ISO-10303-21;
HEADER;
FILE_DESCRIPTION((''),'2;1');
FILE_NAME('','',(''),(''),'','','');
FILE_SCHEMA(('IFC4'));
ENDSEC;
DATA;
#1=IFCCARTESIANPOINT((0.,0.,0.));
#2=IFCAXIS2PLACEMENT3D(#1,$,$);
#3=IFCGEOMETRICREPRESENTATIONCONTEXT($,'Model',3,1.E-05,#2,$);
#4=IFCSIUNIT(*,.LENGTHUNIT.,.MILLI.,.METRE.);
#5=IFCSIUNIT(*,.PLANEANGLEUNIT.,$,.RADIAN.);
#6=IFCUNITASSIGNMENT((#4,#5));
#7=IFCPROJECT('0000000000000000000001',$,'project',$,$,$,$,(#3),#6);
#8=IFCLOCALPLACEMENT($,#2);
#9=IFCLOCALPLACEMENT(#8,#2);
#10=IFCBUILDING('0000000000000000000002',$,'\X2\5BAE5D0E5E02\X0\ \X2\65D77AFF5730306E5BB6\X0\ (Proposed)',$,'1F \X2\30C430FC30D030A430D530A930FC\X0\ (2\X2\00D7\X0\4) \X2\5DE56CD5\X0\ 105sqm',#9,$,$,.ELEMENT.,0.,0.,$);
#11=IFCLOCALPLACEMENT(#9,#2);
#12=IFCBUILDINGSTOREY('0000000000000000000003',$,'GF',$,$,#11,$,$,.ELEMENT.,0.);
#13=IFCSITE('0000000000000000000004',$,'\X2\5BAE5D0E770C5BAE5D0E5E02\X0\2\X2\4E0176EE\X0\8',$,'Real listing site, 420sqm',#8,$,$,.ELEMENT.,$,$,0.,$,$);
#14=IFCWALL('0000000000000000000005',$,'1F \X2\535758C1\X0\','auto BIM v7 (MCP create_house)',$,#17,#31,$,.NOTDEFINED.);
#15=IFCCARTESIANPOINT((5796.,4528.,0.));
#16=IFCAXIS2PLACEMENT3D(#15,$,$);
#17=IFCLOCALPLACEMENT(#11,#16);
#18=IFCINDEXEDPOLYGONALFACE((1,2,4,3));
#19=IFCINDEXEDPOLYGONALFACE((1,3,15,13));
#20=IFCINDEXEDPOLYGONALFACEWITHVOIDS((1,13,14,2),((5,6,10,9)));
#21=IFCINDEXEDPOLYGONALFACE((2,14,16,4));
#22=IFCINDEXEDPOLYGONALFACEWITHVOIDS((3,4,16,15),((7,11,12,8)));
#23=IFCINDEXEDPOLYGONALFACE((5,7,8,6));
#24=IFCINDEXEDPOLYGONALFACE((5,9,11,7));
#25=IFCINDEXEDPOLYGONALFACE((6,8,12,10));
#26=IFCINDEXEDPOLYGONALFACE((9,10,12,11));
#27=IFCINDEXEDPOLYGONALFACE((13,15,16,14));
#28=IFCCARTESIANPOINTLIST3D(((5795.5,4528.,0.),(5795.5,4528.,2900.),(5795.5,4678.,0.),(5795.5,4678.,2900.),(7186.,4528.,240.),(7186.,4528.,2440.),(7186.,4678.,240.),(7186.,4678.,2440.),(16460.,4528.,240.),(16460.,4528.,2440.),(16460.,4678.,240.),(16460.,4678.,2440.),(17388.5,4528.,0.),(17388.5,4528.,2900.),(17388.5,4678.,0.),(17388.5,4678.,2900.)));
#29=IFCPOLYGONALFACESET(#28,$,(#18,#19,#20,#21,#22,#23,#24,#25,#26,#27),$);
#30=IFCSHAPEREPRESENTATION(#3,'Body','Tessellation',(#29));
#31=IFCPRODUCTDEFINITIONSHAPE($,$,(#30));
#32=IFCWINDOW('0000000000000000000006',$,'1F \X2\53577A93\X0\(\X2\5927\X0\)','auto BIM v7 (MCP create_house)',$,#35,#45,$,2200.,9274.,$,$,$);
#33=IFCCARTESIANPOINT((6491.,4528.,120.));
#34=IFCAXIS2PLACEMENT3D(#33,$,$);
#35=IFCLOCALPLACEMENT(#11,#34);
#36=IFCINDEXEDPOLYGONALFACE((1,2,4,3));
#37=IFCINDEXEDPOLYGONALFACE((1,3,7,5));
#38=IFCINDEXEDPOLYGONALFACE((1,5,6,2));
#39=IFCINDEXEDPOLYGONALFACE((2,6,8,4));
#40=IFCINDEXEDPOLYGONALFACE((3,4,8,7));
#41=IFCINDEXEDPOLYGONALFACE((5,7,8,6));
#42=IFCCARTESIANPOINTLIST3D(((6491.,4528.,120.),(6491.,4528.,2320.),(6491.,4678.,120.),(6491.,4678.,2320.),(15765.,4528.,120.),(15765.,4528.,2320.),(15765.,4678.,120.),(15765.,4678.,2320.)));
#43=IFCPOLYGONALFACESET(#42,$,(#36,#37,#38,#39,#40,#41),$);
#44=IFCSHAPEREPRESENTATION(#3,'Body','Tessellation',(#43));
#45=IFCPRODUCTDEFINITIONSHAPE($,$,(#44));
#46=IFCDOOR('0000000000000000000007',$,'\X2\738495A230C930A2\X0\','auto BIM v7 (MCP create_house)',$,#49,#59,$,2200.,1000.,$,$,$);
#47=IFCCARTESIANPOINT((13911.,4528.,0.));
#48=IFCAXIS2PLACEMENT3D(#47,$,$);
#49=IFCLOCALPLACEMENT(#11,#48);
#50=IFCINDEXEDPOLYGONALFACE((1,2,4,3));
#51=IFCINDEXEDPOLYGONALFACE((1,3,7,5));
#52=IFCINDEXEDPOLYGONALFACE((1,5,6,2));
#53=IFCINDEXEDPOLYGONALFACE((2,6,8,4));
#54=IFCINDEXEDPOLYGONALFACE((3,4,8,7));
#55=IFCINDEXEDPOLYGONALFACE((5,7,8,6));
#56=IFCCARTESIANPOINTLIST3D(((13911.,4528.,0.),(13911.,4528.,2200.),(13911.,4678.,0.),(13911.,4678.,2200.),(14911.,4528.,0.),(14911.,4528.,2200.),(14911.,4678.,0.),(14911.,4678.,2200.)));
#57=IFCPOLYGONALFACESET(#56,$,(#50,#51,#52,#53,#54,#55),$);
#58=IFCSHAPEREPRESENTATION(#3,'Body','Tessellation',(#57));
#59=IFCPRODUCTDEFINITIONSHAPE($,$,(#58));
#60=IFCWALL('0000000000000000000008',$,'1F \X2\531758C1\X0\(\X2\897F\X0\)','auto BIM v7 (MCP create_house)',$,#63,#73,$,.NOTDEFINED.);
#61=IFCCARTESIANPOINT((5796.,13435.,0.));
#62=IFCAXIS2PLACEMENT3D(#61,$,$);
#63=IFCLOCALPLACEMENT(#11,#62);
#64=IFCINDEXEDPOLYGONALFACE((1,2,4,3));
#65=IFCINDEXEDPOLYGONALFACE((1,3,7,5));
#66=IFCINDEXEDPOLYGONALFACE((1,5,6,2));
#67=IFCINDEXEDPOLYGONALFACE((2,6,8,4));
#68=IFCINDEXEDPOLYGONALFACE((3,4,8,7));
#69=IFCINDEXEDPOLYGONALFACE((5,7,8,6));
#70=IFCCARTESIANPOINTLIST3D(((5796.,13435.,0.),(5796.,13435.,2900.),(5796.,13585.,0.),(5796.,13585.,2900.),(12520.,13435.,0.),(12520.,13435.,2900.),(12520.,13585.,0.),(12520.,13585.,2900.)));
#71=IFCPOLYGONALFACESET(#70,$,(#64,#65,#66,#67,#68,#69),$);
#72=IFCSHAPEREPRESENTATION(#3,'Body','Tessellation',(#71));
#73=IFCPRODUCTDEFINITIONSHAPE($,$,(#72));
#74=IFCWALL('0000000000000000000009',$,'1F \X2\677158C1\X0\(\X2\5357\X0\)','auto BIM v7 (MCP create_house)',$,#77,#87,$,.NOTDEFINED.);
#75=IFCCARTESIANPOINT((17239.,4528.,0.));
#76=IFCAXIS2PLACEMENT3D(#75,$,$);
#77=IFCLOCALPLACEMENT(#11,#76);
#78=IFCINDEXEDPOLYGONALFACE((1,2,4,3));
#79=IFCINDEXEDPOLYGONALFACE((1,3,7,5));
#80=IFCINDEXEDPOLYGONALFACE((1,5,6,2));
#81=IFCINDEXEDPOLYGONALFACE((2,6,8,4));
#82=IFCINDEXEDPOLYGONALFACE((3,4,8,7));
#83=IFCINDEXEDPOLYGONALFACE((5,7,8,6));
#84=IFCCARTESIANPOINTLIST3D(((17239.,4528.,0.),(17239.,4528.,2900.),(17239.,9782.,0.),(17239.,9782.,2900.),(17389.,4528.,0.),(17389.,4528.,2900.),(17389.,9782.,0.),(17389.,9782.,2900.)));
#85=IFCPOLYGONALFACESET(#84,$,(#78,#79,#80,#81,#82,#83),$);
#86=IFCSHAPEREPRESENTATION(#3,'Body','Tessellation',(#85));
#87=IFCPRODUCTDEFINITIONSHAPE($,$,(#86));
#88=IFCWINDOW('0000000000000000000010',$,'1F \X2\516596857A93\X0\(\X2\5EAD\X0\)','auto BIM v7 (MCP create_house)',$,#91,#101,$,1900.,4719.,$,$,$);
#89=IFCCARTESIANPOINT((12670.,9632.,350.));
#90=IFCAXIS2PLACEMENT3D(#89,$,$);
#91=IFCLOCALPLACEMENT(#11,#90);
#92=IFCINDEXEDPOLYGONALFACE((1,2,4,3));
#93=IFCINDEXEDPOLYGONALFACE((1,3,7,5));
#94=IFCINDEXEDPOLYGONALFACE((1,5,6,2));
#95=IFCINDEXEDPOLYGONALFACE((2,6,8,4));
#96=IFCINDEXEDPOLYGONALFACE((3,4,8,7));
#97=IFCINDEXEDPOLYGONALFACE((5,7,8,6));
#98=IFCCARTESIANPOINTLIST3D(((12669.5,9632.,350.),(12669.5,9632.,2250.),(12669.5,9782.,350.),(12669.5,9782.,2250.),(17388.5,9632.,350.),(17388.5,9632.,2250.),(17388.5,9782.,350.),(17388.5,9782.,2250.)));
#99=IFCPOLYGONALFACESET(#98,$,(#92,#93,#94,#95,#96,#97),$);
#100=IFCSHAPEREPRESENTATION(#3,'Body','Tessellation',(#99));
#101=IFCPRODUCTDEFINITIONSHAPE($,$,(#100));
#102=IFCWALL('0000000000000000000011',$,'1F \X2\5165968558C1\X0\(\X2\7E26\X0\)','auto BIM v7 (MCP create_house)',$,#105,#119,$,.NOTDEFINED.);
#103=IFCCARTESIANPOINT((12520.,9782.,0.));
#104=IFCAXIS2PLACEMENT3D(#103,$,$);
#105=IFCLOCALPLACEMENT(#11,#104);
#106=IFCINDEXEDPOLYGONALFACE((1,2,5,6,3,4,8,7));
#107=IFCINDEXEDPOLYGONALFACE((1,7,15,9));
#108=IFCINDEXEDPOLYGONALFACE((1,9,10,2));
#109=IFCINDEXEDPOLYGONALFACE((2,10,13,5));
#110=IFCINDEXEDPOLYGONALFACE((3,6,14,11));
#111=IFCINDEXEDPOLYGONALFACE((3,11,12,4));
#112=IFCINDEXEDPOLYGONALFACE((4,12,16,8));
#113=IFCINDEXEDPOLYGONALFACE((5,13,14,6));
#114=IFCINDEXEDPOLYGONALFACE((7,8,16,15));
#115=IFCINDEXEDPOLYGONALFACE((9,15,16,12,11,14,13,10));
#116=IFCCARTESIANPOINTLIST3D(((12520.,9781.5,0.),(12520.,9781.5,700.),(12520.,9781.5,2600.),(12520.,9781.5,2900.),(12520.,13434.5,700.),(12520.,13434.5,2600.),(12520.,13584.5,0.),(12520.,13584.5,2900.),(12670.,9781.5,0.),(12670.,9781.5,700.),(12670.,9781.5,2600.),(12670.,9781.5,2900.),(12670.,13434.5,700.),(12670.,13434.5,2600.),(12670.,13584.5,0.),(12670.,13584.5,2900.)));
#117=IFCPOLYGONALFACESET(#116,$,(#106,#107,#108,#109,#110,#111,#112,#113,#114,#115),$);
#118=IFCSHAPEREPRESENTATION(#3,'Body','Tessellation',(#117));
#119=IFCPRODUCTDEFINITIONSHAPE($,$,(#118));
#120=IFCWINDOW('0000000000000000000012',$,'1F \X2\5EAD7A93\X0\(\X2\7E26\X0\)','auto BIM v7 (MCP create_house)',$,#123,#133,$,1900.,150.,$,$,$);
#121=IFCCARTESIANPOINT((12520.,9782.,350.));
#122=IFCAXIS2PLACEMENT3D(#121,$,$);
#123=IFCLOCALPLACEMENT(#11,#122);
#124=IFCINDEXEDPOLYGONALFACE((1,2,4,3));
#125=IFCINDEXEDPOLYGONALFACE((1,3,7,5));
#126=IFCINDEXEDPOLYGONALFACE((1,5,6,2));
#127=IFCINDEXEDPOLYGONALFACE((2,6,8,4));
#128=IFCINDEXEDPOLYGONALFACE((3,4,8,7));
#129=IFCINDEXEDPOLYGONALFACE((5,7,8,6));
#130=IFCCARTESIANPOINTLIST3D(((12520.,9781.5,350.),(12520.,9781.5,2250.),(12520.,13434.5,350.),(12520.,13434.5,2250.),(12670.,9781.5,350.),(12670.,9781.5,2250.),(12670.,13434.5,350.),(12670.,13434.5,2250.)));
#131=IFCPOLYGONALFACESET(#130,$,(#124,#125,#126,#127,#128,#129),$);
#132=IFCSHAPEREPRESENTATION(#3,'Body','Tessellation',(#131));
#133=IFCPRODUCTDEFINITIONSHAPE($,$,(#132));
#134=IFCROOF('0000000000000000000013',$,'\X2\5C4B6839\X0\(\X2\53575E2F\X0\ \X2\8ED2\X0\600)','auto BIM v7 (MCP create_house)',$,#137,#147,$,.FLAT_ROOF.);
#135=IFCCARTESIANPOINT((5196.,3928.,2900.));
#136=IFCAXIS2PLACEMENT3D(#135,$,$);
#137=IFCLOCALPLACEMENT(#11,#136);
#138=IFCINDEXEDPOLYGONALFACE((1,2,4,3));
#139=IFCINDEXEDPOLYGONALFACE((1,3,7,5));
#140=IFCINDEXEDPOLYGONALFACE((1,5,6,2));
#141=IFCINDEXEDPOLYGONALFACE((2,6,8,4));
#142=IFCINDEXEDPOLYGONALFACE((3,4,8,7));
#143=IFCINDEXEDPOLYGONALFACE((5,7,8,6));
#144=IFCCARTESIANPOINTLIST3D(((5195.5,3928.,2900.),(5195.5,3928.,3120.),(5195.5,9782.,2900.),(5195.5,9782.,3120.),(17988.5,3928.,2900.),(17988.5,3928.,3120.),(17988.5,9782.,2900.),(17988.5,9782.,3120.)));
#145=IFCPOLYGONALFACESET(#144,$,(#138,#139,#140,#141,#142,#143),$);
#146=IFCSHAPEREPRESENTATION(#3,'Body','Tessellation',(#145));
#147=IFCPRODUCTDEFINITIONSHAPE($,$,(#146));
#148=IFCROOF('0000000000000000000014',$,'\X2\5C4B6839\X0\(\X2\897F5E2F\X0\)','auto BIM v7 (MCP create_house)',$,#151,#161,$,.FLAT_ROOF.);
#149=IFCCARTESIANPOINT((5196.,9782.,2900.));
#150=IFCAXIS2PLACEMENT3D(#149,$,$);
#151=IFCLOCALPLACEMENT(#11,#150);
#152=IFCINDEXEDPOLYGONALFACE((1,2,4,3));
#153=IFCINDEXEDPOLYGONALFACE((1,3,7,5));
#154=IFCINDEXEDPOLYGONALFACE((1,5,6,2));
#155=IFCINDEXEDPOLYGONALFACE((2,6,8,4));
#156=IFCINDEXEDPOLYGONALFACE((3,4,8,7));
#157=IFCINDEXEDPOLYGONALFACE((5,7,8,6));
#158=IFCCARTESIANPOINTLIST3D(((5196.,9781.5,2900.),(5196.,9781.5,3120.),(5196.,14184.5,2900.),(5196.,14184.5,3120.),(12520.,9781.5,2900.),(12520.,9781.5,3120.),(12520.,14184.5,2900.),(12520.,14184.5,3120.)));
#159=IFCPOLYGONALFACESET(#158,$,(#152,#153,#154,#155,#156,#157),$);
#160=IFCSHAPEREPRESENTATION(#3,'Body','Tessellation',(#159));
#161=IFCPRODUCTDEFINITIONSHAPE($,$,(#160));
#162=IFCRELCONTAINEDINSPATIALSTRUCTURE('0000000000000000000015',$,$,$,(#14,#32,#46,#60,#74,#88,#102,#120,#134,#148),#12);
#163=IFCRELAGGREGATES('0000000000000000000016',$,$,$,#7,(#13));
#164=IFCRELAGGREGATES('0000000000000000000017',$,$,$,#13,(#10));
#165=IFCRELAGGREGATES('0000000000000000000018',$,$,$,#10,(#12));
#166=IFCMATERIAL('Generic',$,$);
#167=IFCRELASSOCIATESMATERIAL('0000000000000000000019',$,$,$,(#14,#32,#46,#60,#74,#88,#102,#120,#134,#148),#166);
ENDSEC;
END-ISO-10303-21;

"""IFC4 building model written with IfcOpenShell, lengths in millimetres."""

from ifc_helpers import new_model, si_unit, frame, frame_2d, origin, place, context, project, spatial, rectangle, extrude, material, element, fill, save


model = new_model("IFC4")

# Units and contexts
model_context = context("Model", 3, precision=1e-05, world=origin())
ifc_project = project(units=[si_unit("LENGTHUNIT", "METRE", prefix="MILLI"), si_unit("PLANEANGLEUNIT", "RADIAN")], contexts=[model_context])

# Site, building, storey
site_placement = place(None, origin())
site = spatial("IfcSite", under=ifc_project, at=site_placement, Name="宮崎県宮崎市2丁目8", ObjectType="Real listing site, 420sqm", CompositionType="ELEMENT", RefElevation=0.0)
building_placement = place(site_placement, origin())
building = spatial("IfcBuilding", under=site, at=building_placement, Name="宮崎市 旗竿地の家 (Proposed)", ObjectType="1F ツーバイフォー (2×4) 工法 105sqm", CompositionType="ELEMENT", ElevationOfRefHeight=0.0, ElevationOfTerrain=0.0)
storey_placement = place(building_placement, origin())
storey = spatial("IfcBuildingStorey", under=building, at=storey_placement, Name="GF", CompositionType="ELEMENT", Elevation=0.0)

# Shared definitions
ifc_material = material(Name="Generic")

# Wall, openings, window, door
wall_1_placement = place(storey_placement, frame((5796.0, 4528.0, 0.0)))
wall_1 = element("IfcWall", 1, at=wall_1_placement, inside=storey, material=ifc_material, Name="1F 南壁", Description="auto BIM v7 (MCP create_house)", PredefinedType="NOTDEFINED", context=model_context, shape_type="SweptSolid", body=[
    extrude(rectangle(XDim=11593.0, YDim=150.0, at=frame_2d((5796.0, 75.0))), frame((5796.0, 4528.0, 0.0)), (0.0, 0.0, 1.0), 2900.0),
])
opening_1_placement = place(storey_placement, frame((6491.0, 4528.0, 120.0)))
opening_1 = element("IfcOpeningElement", 2, at=opening_1_placement, cuts=wall_1, PredefinedType="NOTDEFINED", context=model_context, shape_type="SweptSolid", body=[
    extrude(rectangle(XDim=9274.0, YDim=150.0, at=frame_2d((4637.0, 75.0))), frame((6491.0, 4528.0, 120.0)), (0.0, 0.0, 1.0), 2200.0),
])
opening_2_placement = place(storey_placement, frame((13911.0, 4528.0, 0.0)))
opening_2 = element("IfcOpeningElement", 3, at=opening_2_placement, cuts=wall_1, PredefinedType="NOTDEFINED", context=model_context, shape_type="SweptSolid", body=[
    extrude(rectangle(XDim=1000.0, YDim=150.0, at=frame_2d((500.0, 75.0))), frame((13911.0, 4528.0, 0.0)), (0.0, 0.0, 1.0), 2200.0),
])
window_1_placement = place(storey_placement, frame((6491.0, 4528.0, 120.0)))
window_1 = element("IfcWindow", 4, at=window_1_placement, inside=storey, material=ifc_material, Name="1F 南窓(大)", Description="auto BIM v7 (MCP create_house)", OverallHeight=2200.0, OverallWidth=9274.0, context=model_context, shape_type="SweptSolid", body=[
    extrude(rectangle(XDim=9274.0, YDim=150.0, at=frame_2d((4637.0, 75.0))), frame((6491.0, 4528.0, 120.0)), (0.0, 0.0, 1.0), 2200.0),
])
fill(opening_1, window_1)
door_placement = place(storey_placement, frame((13911.0, 4528.0, 0.0)))
door = element("IfcDoor", 5, at=door_placement, inside=storey, material=ifc_material, Name="玄関ドア", Description="auto BIM v7 (MCP create_house)", OverallHeight=2200.0, OverallWidth=1000.0, context=model_context, shape_type="SweptSolid", body=[
    extrude(rectangle(XDim=1000.0, YDim=150.0, at=frame_2d((500.0, 75.0))), frame((13911.0, 4528.0, 0.0)), (0.0, 0.0, 1.0), 2200.0),
])
fill(opening_2, door)

# Wall
wall_2_placement = place(storey_placement, frame((5796.0, 13435.0, 0.0)))
element("IfcWall", 6, at=wall_2_placement, inside=storey, material=ifc_material, Name="1F 北壁(西)", Description="auto BIM v7 (MCP create_house)", PredefinedType="NOTDEFINED", context=model_context, shape_type="SweptSolid", body=[
    extrude(rectangle(XDim=6724.0, YDim=150.0, at=frame_2d((3362.0, 75.0))), frame((5796.0, 13435.0, 0.0)), (0.0, 0.0, 1.0), 2900.0),
])

# Wall, opening, window
wall_3_placement = place(storey_placement, frame((17239.0, 4528.0, 0.0)))
wall_3 = element("IfcWall", 7, at=wall_3_placement, inside=storey, material=ifc_material, Name="1F 東壁(南)", Description="auto BIM v7 (MCP create_house)", PredefinedType="NOTDEFINED", context=model_context, shape_type="SweptSolid", body=[
    extrude(rectangle(XDim=150.0, YDim=5254.0, at=frame_2d((75.0, 2627.0))), frame((17239.0, 4528.0, 0.0)), (0.0, 0.0, 1.0), 2900.0),
])
opening_3_placement = place(storey_placement, frame((12670.0, 9632.0, 350.0)))
opening_3 = element("IfcOpeningElement", 8, at=opening_3_placement, cuts=wall_3, PredefinedType="NOTDEFINED", context=model_context, shape_type="SweptSolid", body=[
    extrude(rectangle(XDim=4719.0, YDim=150.0, at=frame_2d((2359.0, 75.0))), frame((12670.0, 9632.0, 350.0)), (0.0, 0.0, 1.0), 1900.0),
])
window_2_placement = place(storey_placement, frame((12670.0, 9632.0, 350.0)))
window_2 = element("IfcWindow", 9, at=window_2_placement, inside=storey, material=ifc_material, Name="1F 入隅窓(庭)", Description="auto BIM v7 (MCP create_house)", OverallHeight=1900.0, OverallWidth=4719.0, context=model_context, shape_type="SweptSolid", body=[
    extrude(rectangle(XDim=4719.0, YDim=150.0, at=frame_2d((2359.0, 75.0))), frame((12670.0, 9632.0, 350.0)), (0.0, 0.0, 1.0), 1900.0),
])
fill(opening_3, window_2)

# Wall, opening, window
wall_4_placement = place(storey_placement, frame((12520.0, 9782.0, 0.0)))
wall_4 = element("IfcWall", 10, at=wall_4_placement, inside=storey, material=ifc_material, Name="1F 入隅壁(縦)", Description="auto BIM v7 (MCP create_house)", PredefinedType="NOTDEFINED", context=model_context, shape_type="SweptSolid", body=[
    extrude(rectangle(XDim=150.0, YDim=3803.0, at=frame_2d((75.0, 1901.0))), frame((12520.0, 9782.0, 0.0)), (0.0, 0.0, 1.0), 2900.0),
])
opening_4_placement = place(storey_placement, frame((12520.0, 9782.0, 350.0)))
opening_4 = element("IfcOpeningElement", 11, at=opening_4_placement, cuts=wall_4, PredefinedType="NOTDEFINED", context=model_context, shape_type="SweptSolid", body=[
    extrude(rectangle(XDim=150.0, YDim=3653.0, at=frame_2d((75.0, 1826.0))), frame((12520.0, 9782.0, 350.0)), (0.0, 0.0, 1.0), 1900.0),
])
window_3_placement = place(storey_placement, frame((12520.0, 9782.0, 350.0)))
window_3 = element("IfcWindow", 12, at=window_3_placement, inside=storey, material=ifc_material, Name="1F 庭窓(縦)", Description="auto BIM v7 (MCP create_house)", OverallHeight=1900.0, OverallWidth=150.0, context=model_context, shape_type="SweptSolid", body=[
    extrude(rectangle(XDim=150.0, YDim=3653.0, at=frame_2d((75.0, 1826.0))), frame((12520.0, 9782.0, 350.0)), (0.0, 0.0, 1.0), 1900.0),
])
fill(opening_4, window_3)

# Roofs
roof_1_placement = place(storey_placement, frame((5196.0, 3928.0, 2900.0)))
element("IfcRoof", 13, at=roof_1_placement, inside=storey, material=ifc_material, Name="屋根(南帯 軒600)", Description="auto BIM v7 (MCP create_house)", PredefinedType="FLAT_ROOF", context=model_context, shape_type="SweptSolid", body=[
    extrude(rectangle(XDim=12793.0, YDim=5854.0, at=frame_2d((6396.0, 2927.0))), frame((5196.0, 3928.0, 2900.0)), (0.0, 0.0, 1.0), 220.0),
])
roof_2_placement = place(storey_placement, frame((5196.0, 9782.0, 2900.0)))
element("IfcRoof", 14, at=roof_2_placement, inside=storey, material=ifc_material, Name="屋根(西帯)", Description="auto BIM v7 (MCP create_house)", PredefinedType="FLAT_ROOF", context=model_context, shape_type="SweptSolid", body=[
    extrude(rectangle(XDim=7324.0, YDim=4403.0, at=frame_2d((3662.0, 2201.0))), frame((5196.0, 9782.0, 2900.0)), (0.0, 0.0, 1.0), 220.0),
])

save(model, "model.ifc")
